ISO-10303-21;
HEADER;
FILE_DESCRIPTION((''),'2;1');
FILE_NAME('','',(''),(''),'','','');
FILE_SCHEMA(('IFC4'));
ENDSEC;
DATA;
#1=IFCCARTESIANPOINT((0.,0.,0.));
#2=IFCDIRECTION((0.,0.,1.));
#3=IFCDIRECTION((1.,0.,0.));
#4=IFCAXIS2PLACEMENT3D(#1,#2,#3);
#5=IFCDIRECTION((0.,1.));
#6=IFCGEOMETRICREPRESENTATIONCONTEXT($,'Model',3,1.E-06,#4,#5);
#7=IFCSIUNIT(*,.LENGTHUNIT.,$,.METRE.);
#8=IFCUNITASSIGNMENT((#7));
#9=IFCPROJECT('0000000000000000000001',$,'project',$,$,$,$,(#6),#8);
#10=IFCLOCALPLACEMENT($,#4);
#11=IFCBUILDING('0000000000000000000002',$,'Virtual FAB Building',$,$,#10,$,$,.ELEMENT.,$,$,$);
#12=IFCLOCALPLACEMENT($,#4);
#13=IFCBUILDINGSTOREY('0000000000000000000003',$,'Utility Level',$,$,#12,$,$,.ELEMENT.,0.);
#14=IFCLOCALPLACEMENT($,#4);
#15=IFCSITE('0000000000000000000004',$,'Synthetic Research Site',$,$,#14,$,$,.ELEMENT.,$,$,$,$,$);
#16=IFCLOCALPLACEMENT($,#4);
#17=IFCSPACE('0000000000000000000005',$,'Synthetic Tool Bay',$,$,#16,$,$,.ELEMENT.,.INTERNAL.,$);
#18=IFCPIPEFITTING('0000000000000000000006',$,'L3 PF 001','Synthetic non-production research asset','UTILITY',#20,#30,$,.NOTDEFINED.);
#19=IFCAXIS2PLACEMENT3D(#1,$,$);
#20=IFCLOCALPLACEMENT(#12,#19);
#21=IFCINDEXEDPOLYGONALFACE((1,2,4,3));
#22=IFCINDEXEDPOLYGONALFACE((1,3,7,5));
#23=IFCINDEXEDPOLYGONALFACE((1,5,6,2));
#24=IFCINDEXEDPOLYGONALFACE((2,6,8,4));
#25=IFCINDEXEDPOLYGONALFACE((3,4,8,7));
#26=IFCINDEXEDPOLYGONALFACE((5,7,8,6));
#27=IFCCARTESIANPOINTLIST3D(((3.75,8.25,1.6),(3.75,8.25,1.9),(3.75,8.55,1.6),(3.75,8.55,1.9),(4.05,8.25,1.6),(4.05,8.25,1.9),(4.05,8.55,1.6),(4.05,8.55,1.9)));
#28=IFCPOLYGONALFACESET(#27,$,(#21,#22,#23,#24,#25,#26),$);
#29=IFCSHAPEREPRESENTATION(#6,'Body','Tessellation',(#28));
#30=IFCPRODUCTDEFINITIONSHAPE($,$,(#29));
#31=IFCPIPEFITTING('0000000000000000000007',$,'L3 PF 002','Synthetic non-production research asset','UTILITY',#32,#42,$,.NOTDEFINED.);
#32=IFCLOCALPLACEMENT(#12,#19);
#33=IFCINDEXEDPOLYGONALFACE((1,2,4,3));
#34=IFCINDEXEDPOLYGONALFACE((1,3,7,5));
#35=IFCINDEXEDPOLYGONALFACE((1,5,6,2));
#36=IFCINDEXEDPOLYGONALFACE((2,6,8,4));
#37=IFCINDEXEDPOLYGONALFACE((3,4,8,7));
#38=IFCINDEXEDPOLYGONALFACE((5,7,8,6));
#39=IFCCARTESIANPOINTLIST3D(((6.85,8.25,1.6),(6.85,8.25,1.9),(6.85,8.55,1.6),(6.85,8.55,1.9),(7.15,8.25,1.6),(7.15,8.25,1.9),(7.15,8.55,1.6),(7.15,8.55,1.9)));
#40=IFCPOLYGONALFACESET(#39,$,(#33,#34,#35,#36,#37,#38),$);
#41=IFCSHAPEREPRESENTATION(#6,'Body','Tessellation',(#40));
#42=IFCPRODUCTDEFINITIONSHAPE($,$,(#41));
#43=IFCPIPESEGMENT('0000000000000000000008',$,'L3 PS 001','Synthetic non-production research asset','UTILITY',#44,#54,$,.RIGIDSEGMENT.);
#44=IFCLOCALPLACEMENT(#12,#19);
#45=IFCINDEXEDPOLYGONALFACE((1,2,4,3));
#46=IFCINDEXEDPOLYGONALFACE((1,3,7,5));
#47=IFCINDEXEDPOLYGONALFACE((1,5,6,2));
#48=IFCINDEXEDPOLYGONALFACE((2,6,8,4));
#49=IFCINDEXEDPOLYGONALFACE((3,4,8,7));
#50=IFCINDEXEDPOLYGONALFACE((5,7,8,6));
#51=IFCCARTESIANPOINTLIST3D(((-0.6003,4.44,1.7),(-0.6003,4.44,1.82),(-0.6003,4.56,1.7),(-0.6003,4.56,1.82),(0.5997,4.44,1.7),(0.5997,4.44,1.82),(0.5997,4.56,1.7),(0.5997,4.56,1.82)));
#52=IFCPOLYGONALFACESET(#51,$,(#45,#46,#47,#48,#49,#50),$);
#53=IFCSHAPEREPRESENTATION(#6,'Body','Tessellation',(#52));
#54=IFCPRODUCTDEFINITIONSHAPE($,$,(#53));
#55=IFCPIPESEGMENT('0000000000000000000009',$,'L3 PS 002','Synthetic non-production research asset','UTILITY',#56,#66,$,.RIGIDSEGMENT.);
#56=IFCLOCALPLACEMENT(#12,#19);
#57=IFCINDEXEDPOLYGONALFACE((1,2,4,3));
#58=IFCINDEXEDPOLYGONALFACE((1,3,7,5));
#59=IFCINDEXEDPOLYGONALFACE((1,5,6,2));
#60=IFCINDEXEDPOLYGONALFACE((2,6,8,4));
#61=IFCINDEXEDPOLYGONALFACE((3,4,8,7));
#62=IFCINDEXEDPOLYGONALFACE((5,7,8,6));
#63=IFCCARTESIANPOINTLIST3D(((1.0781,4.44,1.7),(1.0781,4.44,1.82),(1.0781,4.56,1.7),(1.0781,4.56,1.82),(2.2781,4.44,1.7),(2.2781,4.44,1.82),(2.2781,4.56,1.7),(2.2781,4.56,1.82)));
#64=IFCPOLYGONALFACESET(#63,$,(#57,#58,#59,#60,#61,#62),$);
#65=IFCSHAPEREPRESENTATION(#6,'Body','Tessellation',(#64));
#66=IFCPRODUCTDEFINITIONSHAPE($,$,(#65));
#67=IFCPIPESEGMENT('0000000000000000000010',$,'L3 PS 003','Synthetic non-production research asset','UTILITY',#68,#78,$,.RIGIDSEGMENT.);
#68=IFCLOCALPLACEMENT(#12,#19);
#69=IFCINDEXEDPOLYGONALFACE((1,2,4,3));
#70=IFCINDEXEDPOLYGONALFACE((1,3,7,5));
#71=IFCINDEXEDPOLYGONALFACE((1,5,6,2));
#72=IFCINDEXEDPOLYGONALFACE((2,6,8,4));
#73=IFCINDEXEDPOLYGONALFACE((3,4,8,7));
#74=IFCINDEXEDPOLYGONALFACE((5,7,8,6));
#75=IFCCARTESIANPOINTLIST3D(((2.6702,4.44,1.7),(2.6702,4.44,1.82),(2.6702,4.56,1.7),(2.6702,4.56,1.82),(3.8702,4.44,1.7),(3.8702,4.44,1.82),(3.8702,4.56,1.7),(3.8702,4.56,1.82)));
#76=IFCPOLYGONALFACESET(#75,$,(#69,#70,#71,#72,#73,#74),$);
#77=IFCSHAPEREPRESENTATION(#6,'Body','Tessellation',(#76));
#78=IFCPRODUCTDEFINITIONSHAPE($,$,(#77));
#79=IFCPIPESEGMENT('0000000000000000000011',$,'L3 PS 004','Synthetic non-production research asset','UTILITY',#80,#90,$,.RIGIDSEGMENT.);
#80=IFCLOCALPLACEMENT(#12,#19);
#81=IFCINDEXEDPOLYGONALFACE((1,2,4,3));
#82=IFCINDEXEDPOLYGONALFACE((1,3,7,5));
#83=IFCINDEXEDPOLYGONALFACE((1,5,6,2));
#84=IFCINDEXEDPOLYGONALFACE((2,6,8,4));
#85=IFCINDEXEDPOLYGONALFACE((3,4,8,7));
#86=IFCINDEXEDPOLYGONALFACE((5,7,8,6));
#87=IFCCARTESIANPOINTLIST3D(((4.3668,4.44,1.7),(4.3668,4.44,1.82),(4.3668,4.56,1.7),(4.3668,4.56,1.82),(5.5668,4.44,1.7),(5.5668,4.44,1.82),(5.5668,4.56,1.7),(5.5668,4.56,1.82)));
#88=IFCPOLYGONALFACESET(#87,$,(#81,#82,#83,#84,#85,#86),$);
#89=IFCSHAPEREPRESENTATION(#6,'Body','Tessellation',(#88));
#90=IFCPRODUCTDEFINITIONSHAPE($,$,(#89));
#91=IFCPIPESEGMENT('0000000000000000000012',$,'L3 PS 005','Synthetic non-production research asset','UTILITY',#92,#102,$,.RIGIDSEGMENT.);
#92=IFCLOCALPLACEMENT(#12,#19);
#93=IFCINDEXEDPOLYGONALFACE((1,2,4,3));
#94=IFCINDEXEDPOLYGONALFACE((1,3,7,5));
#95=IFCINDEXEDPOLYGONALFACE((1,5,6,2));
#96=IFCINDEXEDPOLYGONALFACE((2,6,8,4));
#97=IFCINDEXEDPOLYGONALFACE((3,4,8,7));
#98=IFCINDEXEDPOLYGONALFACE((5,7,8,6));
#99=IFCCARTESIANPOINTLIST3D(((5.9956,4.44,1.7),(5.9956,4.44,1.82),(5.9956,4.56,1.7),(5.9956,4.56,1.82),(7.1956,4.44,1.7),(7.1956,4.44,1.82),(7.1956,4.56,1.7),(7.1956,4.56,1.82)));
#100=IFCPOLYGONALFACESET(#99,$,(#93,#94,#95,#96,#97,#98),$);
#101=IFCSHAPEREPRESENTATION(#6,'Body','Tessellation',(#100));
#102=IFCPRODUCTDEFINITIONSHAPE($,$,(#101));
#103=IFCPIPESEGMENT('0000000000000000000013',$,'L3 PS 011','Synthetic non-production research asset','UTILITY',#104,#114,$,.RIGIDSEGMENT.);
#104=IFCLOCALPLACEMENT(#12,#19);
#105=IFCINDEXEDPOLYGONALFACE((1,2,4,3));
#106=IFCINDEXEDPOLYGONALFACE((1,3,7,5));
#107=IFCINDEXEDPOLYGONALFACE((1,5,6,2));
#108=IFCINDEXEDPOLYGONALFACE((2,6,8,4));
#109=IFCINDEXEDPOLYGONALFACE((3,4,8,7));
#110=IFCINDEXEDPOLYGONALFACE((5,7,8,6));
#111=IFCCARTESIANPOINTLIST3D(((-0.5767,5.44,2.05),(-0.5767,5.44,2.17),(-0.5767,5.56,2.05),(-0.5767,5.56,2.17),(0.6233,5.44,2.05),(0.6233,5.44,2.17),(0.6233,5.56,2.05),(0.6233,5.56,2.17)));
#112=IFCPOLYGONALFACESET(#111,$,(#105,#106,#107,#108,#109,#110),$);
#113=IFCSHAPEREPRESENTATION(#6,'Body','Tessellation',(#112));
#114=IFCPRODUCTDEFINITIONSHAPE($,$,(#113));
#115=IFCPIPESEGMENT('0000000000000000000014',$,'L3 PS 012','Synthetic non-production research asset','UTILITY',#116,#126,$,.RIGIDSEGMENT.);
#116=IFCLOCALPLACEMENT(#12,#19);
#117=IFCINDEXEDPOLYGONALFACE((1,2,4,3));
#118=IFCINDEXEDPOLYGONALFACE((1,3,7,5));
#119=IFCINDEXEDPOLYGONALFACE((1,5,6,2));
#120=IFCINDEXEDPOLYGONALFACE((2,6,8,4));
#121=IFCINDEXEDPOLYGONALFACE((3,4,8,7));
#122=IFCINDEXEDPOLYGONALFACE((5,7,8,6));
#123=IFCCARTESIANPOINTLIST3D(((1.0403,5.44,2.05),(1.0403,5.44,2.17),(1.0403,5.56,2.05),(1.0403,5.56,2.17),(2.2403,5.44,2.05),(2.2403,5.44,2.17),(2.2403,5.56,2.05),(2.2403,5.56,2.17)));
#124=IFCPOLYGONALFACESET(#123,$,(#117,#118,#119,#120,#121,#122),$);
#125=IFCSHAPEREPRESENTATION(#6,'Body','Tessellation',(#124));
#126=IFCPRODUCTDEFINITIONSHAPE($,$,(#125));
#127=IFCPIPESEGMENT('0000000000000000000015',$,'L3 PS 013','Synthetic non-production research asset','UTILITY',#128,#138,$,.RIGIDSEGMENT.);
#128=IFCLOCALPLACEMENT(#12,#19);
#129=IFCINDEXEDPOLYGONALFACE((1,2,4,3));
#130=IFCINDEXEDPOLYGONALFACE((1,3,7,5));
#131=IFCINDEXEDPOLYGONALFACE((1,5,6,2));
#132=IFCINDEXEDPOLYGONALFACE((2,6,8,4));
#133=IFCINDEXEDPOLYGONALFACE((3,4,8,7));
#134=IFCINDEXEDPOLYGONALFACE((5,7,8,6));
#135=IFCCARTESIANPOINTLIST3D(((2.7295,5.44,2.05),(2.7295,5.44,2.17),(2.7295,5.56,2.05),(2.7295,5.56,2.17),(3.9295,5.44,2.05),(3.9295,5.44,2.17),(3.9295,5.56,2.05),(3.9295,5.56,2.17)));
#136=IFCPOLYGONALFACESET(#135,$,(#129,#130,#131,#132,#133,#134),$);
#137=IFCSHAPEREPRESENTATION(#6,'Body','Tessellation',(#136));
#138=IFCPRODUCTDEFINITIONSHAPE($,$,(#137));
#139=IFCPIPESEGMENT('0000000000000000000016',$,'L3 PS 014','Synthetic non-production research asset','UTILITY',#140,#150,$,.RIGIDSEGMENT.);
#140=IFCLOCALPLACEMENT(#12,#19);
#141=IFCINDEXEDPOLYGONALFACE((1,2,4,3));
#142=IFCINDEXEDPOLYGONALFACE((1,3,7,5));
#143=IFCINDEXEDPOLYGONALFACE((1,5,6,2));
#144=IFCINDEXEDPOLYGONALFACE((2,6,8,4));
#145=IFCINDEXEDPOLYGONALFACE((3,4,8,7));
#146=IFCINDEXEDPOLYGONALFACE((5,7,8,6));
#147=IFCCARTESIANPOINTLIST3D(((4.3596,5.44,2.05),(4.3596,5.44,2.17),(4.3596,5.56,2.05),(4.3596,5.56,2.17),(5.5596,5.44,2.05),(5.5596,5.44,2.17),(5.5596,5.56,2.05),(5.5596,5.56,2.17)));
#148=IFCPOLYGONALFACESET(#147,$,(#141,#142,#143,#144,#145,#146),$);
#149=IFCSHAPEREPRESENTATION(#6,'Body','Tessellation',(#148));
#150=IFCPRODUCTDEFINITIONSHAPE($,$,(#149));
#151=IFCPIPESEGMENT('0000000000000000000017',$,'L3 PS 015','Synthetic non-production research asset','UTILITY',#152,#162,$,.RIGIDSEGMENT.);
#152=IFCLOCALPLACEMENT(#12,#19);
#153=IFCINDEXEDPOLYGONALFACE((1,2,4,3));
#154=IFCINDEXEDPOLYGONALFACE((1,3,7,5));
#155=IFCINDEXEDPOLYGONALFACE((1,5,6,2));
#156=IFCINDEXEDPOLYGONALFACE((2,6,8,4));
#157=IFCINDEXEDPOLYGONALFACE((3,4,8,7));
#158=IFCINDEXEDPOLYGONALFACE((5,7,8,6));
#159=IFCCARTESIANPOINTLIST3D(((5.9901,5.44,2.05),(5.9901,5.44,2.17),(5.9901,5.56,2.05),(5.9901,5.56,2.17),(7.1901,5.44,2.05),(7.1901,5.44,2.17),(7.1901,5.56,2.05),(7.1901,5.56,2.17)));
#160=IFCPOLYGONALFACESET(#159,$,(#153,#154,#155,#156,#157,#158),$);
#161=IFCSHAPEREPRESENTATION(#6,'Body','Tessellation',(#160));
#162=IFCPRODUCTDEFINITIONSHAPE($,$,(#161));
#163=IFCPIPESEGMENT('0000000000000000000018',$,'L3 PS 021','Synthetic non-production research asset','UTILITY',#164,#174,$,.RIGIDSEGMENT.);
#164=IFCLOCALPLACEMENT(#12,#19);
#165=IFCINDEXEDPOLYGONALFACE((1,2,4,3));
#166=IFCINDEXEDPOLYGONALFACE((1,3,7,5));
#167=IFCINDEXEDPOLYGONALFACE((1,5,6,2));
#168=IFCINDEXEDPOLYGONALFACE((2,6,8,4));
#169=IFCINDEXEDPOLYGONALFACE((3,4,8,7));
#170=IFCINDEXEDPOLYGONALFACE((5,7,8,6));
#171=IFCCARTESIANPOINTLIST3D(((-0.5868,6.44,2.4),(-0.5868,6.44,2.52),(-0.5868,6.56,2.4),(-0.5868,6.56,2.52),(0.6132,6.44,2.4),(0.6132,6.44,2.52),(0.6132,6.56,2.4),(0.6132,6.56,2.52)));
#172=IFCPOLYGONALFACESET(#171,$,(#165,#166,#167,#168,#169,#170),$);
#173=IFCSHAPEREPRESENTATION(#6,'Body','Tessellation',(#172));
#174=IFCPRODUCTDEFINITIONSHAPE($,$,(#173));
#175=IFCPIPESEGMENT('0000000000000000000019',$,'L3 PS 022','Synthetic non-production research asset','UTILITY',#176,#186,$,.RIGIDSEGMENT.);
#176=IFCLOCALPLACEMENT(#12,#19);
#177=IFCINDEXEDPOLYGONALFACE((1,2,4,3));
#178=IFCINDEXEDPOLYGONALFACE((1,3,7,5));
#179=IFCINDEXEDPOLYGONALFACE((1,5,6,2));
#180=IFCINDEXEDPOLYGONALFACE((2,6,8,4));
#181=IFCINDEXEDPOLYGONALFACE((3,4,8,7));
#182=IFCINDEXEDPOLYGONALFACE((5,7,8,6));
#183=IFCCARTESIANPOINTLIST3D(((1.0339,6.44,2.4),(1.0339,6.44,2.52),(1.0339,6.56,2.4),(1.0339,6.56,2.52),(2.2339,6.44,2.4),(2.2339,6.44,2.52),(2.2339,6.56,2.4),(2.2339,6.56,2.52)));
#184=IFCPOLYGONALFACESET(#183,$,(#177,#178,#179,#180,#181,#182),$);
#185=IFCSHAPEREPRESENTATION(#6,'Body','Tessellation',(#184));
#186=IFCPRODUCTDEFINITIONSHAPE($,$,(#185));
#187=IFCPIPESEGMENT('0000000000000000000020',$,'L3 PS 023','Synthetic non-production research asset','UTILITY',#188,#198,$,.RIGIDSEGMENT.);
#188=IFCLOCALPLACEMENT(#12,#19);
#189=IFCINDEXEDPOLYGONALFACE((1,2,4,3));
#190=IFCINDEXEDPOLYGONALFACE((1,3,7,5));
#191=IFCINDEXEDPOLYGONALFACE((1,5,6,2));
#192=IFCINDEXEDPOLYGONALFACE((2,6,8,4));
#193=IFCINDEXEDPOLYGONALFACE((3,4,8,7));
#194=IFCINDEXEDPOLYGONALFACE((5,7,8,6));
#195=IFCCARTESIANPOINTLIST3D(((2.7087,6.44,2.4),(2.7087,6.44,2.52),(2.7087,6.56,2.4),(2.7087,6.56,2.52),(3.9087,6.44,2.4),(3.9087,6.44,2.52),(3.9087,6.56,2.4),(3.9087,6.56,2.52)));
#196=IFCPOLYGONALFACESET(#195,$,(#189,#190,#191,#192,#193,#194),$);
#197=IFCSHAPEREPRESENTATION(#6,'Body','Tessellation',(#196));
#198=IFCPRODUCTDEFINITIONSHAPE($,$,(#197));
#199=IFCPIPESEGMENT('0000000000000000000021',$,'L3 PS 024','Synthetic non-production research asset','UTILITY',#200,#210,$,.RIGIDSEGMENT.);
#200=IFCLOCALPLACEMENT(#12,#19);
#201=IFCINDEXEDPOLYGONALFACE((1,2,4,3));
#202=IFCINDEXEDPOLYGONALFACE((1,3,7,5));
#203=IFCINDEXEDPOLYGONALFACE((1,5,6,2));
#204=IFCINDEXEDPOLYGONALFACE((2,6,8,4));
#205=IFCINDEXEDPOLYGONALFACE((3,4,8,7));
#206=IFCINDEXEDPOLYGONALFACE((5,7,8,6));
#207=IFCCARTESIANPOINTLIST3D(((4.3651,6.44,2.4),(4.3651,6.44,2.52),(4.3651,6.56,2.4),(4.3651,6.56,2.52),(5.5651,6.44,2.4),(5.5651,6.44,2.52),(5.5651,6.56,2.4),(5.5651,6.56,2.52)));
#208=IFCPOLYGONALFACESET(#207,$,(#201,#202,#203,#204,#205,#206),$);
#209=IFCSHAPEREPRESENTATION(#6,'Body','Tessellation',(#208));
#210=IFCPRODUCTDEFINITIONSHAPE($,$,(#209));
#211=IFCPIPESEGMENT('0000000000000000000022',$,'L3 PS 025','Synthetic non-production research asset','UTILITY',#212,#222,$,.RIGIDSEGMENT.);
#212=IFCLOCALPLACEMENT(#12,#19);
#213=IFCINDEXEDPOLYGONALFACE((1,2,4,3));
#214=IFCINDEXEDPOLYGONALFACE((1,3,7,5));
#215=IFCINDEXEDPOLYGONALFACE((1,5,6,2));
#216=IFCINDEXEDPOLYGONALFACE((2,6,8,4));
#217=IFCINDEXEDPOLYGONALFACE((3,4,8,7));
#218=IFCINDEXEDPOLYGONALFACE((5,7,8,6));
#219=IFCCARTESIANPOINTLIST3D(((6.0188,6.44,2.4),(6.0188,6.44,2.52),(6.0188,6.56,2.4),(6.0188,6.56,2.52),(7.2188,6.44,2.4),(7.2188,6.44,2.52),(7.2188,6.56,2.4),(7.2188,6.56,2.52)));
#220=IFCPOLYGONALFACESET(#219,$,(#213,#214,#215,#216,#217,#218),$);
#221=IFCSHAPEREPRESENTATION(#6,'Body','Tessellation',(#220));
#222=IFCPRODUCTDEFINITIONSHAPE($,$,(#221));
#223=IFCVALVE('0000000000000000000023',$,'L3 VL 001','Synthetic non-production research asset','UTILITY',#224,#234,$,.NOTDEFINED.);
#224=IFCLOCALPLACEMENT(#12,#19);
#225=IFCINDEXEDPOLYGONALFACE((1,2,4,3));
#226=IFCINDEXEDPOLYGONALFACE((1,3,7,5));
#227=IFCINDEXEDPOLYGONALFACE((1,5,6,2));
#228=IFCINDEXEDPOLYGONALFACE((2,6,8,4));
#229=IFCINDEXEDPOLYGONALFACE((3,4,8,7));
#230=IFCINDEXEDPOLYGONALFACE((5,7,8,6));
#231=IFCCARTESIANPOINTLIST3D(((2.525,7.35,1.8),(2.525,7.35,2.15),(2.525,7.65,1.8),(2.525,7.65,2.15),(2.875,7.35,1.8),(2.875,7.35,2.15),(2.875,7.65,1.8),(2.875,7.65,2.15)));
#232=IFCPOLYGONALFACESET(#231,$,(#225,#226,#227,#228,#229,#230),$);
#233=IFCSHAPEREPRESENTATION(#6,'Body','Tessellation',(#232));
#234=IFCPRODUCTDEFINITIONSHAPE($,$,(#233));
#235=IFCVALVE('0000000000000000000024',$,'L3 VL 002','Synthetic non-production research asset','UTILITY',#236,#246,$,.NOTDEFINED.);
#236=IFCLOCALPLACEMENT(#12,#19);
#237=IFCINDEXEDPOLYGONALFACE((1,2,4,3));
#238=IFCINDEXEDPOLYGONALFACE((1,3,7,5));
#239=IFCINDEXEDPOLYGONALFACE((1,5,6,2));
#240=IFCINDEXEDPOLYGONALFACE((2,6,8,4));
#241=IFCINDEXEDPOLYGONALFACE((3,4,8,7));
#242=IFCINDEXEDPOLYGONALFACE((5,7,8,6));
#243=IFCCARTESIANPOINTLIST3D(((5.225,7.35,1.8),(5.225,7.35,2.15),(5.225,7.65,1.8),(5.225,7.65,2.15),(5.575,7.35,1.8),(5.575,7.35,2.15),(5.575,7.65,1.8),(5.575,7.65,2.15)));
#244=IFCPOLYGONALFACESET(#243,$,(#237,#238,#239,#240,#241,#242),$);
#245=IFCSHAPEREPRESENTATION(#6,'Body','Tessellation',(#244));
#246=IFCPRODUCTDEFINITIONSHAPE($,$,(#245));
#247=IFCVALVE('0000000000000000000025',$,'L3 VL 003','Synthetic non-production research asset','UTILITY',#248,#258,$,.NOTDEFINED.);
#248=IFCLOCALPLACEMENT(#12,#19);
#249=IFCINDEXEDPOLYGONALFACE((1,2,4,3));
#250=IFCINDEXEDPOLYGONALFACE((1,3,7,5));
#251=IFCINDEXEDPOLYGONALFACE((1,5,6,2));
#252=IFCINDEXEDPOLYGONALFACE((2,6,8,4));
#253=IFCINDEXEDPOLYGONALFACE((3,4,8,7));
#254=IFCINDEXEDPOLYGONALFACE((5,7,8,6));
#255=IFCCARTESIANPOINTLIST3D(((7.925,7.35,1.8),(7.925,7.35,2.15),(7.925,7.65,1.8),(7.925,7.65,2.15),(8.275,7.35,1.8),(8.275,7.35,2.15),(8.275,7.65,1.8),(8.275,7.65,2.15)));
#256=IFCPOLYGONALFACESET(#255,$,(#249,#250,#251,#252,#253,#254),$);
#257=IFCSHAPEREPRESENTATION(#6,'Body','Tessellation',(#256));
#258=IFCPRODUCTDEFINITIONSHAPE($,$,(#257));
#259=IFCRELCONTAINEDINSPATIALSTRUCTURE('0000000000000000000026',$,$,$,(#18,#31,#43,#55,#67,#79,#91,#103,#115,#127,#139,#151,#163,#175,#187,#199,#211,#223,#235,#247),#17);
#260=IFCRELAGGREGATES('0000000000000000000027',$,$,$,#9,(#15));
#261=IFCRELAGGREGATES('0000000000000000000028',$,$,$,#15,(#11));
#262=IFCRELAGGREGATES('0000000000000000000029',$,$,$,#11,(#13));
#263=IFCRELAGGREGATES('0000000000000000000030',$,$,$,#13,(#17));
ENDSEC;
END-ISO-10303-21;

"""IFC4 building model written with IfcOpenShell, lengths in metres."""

from ifc_helpers import new_model, si_unit, direction, frame, origin_with_axes, origin_2d_with_axis, place, context, project, spatial, rectangle, extrude, element, save


model = new_model("IFC4")

# Units and contexts
model_context = context("Model", 3, precision=1e-06, world=origin_with_axes(), true_north=direction((0.0, 1.0)))
ifc_project = project(units=[si_unit("LENGTHUNIT", "METRE")], contexts=[model_context])

# Site, building, storey, space
site_placement = place(None, origin_with_axes())
site = spatial("IfcSite", under=ifc_project, at=site_placement, Name="Synthetic Research Site", CompositionType="ELEMENT")
building_placement = place(None, origin_with_axes())
building = spatial("IfcBuilding", under=site, at=building_placement, Name="Virtual FAB Building", CompositionType="ELEMENT")
storey_placement = place(None, origin_with_axes())
storey = spatial("IfcBuildingStorey", under=building, at=storey_placement, Name="Utility Level", CompositionType="ELEMENT", Elevation=0.0)
space_placement = place(None, origin_with_axes())
space = spatial("IfcSpace", under=storey, at=space_placement, Name="Synthetic Tool Bay", CompositionType="ELEMENT", PredefinedType="INTERNAL")

# Pipe fittings
for number, where, z_axis, x_axis, name in (
    (1, (3.9, 8.4, 1.6), (0.0, 0.0, 1.0), (1.0, 0.0, 0.0), "L3 PF 001"),
    (2, (7.0, 8.4, 1.6), (0.0, 0.0, 1.0), (1.0, 0.0, 0.0), "L3 PF 002"),
):
    element("IfcPipeFitting", number, at=place(None, frame(where, z_axis=z_axis, x_axis=x_axis)), inside=space, Name=name, Description="Synthetic non-production research asset", ObjectType="UTILITY", PredefinedType="NOTDEFINED", context=model_context, shape_type="SweptSolid", body=[
        extrude(rectangle(XDim=0.3, YDim=0.3, at=origin_2d_with_axis()), origin_with_axes(), (0.0, 0.0, 1.0), 0.3),
    ])

# Pipe segments
for number, where, z_axis, x_axis, name in (
    (3, (-0.0003, 4.5, 1.7), (0.0, 0.0, 1.0), (1.0, 0.0, 0.0), "L3 PS 001"),
    (4, (1.6781, 4.5, 1.7), (0.0, 0.0, 1.0), (1.0, 0.0, 0.0), "L3 PS 002"),
    (5, (3.2702, 4.5, 1.7), (0.0, 0.0, 1.0), (1.0, 0.0, 0.0), "L3 PS 003"),
    (6, (4.9668, 4.5, 1.7), (0.0, 0.0, 1.0), (1.0, 0.0, 0.0), "L3 PS 004"),
    (7, (6.5956, 4.5, 1.7), (0.0, 0.0, 1.0), (1.0, 0.0, 0.0), "L3 PS 005"),
    (8, (0.0233, 5.5, 2.05), (0.0, 0.0, 1.0), (1.0, 0.0, 0.0), "L3 PS 011"),
    (9, (1.6403, 5.5, 2.05), (0.0, 0.0, 1.0), (1.0, 0.0, 0.0), "L3 PS 012"),
    (10, (3.3295, 5.5, 2.05), (0.0, 0.0, 1.0), (1.0, 0.0, 0.0), "L3 PS 013"),
    (11, (4.9596, 5.5, 2.05), (0.0, 0.0, 1.0), (1.0, 0.0, 0.0), "L3 PS 014"),
    (12, (6.5901, 5.5, 2.05), (0.0, 0.0, 1.0), (1.0, 0.0, 0.0), "L3 PS 015"),
    (13, (0.0132, 6.5, 2.4), (0.0, 0.0, 1.0), (1.0, 0.0, 0.0), "L3 PS 021"),
    (14, (1.6339, 6.5, 2.4), (0.0, 0.0, 1.0), (1.0, 0.0, 0.0), "L3 PS 022"),
    (15, (3.3087, 6.5, 2.4), (0.0, 0.0, 1.0), (1.0, 0.0, 0.0), "L3 PS 023"),
    (16, (4.9651, 6.5, 2.4), (0.0, 0.0, 1.0), (1.0, 0.0, 0.0), "L3 PS 024"),
    (17, (6.6188, 6.5, 2.4), (0.0, 0.0, 1.0), (1.0, 0.0, 0.0), "L3 PS 025"),
):
    element("IfcPipeSegment", number, at=place(None, frame(where, z_axis=z_axis, x_axis=x_axis)), inside=space, Name=name, Description="Synthetic non-production research asset", ObjectType="UTILITY", PredefinedType="RIGIDSEGMENT", context=model_context, shape_type="SweptSolid", body=[
        extrude(rectangle(XDim=1.2, YDim=0.12, at=origin_2d_with_axis()), origin_with_axes(), (0.0, 0.0, 1.0), 0.12),
    ])

# Valves
for number, where, z_axis, x_axis, name in (
    (18, (2.7, 7.5, 1.8), (0.0, 0.0, 1.0), (1.0, 0.0, 0.0), "L3 VL 001"),
    (19, (5.4, 7.5, 1.8), (0.0, 0.0, 1.0), (1.0, 0.0, 0.0), "L3 VL 002"),
    (20, (8.1, 7.5, 1.8), (0.0, 0.0, 1.0), (1.0, 0.0, 0.0), "L3 VL 003"),
):
    element("IfcValve", number, at=place(None, frame(where, z_axis=z_axis, x_axis=x_axis)), inside=space, Name=name, Description="Synthetic non-production research asset", ObjectType="UTILITY", PredefinedType="NOTDEFINED", context=model_context, shape_type="SweptSolid", body=[
        extrude(rectangle(XDim=0.35, YDim=0.3, at=origin_2d_with_axis()), origin_with_axes(), (0.0, 0.0, 1.0), 0.35),
    ])

save(model, "model.ifc")
